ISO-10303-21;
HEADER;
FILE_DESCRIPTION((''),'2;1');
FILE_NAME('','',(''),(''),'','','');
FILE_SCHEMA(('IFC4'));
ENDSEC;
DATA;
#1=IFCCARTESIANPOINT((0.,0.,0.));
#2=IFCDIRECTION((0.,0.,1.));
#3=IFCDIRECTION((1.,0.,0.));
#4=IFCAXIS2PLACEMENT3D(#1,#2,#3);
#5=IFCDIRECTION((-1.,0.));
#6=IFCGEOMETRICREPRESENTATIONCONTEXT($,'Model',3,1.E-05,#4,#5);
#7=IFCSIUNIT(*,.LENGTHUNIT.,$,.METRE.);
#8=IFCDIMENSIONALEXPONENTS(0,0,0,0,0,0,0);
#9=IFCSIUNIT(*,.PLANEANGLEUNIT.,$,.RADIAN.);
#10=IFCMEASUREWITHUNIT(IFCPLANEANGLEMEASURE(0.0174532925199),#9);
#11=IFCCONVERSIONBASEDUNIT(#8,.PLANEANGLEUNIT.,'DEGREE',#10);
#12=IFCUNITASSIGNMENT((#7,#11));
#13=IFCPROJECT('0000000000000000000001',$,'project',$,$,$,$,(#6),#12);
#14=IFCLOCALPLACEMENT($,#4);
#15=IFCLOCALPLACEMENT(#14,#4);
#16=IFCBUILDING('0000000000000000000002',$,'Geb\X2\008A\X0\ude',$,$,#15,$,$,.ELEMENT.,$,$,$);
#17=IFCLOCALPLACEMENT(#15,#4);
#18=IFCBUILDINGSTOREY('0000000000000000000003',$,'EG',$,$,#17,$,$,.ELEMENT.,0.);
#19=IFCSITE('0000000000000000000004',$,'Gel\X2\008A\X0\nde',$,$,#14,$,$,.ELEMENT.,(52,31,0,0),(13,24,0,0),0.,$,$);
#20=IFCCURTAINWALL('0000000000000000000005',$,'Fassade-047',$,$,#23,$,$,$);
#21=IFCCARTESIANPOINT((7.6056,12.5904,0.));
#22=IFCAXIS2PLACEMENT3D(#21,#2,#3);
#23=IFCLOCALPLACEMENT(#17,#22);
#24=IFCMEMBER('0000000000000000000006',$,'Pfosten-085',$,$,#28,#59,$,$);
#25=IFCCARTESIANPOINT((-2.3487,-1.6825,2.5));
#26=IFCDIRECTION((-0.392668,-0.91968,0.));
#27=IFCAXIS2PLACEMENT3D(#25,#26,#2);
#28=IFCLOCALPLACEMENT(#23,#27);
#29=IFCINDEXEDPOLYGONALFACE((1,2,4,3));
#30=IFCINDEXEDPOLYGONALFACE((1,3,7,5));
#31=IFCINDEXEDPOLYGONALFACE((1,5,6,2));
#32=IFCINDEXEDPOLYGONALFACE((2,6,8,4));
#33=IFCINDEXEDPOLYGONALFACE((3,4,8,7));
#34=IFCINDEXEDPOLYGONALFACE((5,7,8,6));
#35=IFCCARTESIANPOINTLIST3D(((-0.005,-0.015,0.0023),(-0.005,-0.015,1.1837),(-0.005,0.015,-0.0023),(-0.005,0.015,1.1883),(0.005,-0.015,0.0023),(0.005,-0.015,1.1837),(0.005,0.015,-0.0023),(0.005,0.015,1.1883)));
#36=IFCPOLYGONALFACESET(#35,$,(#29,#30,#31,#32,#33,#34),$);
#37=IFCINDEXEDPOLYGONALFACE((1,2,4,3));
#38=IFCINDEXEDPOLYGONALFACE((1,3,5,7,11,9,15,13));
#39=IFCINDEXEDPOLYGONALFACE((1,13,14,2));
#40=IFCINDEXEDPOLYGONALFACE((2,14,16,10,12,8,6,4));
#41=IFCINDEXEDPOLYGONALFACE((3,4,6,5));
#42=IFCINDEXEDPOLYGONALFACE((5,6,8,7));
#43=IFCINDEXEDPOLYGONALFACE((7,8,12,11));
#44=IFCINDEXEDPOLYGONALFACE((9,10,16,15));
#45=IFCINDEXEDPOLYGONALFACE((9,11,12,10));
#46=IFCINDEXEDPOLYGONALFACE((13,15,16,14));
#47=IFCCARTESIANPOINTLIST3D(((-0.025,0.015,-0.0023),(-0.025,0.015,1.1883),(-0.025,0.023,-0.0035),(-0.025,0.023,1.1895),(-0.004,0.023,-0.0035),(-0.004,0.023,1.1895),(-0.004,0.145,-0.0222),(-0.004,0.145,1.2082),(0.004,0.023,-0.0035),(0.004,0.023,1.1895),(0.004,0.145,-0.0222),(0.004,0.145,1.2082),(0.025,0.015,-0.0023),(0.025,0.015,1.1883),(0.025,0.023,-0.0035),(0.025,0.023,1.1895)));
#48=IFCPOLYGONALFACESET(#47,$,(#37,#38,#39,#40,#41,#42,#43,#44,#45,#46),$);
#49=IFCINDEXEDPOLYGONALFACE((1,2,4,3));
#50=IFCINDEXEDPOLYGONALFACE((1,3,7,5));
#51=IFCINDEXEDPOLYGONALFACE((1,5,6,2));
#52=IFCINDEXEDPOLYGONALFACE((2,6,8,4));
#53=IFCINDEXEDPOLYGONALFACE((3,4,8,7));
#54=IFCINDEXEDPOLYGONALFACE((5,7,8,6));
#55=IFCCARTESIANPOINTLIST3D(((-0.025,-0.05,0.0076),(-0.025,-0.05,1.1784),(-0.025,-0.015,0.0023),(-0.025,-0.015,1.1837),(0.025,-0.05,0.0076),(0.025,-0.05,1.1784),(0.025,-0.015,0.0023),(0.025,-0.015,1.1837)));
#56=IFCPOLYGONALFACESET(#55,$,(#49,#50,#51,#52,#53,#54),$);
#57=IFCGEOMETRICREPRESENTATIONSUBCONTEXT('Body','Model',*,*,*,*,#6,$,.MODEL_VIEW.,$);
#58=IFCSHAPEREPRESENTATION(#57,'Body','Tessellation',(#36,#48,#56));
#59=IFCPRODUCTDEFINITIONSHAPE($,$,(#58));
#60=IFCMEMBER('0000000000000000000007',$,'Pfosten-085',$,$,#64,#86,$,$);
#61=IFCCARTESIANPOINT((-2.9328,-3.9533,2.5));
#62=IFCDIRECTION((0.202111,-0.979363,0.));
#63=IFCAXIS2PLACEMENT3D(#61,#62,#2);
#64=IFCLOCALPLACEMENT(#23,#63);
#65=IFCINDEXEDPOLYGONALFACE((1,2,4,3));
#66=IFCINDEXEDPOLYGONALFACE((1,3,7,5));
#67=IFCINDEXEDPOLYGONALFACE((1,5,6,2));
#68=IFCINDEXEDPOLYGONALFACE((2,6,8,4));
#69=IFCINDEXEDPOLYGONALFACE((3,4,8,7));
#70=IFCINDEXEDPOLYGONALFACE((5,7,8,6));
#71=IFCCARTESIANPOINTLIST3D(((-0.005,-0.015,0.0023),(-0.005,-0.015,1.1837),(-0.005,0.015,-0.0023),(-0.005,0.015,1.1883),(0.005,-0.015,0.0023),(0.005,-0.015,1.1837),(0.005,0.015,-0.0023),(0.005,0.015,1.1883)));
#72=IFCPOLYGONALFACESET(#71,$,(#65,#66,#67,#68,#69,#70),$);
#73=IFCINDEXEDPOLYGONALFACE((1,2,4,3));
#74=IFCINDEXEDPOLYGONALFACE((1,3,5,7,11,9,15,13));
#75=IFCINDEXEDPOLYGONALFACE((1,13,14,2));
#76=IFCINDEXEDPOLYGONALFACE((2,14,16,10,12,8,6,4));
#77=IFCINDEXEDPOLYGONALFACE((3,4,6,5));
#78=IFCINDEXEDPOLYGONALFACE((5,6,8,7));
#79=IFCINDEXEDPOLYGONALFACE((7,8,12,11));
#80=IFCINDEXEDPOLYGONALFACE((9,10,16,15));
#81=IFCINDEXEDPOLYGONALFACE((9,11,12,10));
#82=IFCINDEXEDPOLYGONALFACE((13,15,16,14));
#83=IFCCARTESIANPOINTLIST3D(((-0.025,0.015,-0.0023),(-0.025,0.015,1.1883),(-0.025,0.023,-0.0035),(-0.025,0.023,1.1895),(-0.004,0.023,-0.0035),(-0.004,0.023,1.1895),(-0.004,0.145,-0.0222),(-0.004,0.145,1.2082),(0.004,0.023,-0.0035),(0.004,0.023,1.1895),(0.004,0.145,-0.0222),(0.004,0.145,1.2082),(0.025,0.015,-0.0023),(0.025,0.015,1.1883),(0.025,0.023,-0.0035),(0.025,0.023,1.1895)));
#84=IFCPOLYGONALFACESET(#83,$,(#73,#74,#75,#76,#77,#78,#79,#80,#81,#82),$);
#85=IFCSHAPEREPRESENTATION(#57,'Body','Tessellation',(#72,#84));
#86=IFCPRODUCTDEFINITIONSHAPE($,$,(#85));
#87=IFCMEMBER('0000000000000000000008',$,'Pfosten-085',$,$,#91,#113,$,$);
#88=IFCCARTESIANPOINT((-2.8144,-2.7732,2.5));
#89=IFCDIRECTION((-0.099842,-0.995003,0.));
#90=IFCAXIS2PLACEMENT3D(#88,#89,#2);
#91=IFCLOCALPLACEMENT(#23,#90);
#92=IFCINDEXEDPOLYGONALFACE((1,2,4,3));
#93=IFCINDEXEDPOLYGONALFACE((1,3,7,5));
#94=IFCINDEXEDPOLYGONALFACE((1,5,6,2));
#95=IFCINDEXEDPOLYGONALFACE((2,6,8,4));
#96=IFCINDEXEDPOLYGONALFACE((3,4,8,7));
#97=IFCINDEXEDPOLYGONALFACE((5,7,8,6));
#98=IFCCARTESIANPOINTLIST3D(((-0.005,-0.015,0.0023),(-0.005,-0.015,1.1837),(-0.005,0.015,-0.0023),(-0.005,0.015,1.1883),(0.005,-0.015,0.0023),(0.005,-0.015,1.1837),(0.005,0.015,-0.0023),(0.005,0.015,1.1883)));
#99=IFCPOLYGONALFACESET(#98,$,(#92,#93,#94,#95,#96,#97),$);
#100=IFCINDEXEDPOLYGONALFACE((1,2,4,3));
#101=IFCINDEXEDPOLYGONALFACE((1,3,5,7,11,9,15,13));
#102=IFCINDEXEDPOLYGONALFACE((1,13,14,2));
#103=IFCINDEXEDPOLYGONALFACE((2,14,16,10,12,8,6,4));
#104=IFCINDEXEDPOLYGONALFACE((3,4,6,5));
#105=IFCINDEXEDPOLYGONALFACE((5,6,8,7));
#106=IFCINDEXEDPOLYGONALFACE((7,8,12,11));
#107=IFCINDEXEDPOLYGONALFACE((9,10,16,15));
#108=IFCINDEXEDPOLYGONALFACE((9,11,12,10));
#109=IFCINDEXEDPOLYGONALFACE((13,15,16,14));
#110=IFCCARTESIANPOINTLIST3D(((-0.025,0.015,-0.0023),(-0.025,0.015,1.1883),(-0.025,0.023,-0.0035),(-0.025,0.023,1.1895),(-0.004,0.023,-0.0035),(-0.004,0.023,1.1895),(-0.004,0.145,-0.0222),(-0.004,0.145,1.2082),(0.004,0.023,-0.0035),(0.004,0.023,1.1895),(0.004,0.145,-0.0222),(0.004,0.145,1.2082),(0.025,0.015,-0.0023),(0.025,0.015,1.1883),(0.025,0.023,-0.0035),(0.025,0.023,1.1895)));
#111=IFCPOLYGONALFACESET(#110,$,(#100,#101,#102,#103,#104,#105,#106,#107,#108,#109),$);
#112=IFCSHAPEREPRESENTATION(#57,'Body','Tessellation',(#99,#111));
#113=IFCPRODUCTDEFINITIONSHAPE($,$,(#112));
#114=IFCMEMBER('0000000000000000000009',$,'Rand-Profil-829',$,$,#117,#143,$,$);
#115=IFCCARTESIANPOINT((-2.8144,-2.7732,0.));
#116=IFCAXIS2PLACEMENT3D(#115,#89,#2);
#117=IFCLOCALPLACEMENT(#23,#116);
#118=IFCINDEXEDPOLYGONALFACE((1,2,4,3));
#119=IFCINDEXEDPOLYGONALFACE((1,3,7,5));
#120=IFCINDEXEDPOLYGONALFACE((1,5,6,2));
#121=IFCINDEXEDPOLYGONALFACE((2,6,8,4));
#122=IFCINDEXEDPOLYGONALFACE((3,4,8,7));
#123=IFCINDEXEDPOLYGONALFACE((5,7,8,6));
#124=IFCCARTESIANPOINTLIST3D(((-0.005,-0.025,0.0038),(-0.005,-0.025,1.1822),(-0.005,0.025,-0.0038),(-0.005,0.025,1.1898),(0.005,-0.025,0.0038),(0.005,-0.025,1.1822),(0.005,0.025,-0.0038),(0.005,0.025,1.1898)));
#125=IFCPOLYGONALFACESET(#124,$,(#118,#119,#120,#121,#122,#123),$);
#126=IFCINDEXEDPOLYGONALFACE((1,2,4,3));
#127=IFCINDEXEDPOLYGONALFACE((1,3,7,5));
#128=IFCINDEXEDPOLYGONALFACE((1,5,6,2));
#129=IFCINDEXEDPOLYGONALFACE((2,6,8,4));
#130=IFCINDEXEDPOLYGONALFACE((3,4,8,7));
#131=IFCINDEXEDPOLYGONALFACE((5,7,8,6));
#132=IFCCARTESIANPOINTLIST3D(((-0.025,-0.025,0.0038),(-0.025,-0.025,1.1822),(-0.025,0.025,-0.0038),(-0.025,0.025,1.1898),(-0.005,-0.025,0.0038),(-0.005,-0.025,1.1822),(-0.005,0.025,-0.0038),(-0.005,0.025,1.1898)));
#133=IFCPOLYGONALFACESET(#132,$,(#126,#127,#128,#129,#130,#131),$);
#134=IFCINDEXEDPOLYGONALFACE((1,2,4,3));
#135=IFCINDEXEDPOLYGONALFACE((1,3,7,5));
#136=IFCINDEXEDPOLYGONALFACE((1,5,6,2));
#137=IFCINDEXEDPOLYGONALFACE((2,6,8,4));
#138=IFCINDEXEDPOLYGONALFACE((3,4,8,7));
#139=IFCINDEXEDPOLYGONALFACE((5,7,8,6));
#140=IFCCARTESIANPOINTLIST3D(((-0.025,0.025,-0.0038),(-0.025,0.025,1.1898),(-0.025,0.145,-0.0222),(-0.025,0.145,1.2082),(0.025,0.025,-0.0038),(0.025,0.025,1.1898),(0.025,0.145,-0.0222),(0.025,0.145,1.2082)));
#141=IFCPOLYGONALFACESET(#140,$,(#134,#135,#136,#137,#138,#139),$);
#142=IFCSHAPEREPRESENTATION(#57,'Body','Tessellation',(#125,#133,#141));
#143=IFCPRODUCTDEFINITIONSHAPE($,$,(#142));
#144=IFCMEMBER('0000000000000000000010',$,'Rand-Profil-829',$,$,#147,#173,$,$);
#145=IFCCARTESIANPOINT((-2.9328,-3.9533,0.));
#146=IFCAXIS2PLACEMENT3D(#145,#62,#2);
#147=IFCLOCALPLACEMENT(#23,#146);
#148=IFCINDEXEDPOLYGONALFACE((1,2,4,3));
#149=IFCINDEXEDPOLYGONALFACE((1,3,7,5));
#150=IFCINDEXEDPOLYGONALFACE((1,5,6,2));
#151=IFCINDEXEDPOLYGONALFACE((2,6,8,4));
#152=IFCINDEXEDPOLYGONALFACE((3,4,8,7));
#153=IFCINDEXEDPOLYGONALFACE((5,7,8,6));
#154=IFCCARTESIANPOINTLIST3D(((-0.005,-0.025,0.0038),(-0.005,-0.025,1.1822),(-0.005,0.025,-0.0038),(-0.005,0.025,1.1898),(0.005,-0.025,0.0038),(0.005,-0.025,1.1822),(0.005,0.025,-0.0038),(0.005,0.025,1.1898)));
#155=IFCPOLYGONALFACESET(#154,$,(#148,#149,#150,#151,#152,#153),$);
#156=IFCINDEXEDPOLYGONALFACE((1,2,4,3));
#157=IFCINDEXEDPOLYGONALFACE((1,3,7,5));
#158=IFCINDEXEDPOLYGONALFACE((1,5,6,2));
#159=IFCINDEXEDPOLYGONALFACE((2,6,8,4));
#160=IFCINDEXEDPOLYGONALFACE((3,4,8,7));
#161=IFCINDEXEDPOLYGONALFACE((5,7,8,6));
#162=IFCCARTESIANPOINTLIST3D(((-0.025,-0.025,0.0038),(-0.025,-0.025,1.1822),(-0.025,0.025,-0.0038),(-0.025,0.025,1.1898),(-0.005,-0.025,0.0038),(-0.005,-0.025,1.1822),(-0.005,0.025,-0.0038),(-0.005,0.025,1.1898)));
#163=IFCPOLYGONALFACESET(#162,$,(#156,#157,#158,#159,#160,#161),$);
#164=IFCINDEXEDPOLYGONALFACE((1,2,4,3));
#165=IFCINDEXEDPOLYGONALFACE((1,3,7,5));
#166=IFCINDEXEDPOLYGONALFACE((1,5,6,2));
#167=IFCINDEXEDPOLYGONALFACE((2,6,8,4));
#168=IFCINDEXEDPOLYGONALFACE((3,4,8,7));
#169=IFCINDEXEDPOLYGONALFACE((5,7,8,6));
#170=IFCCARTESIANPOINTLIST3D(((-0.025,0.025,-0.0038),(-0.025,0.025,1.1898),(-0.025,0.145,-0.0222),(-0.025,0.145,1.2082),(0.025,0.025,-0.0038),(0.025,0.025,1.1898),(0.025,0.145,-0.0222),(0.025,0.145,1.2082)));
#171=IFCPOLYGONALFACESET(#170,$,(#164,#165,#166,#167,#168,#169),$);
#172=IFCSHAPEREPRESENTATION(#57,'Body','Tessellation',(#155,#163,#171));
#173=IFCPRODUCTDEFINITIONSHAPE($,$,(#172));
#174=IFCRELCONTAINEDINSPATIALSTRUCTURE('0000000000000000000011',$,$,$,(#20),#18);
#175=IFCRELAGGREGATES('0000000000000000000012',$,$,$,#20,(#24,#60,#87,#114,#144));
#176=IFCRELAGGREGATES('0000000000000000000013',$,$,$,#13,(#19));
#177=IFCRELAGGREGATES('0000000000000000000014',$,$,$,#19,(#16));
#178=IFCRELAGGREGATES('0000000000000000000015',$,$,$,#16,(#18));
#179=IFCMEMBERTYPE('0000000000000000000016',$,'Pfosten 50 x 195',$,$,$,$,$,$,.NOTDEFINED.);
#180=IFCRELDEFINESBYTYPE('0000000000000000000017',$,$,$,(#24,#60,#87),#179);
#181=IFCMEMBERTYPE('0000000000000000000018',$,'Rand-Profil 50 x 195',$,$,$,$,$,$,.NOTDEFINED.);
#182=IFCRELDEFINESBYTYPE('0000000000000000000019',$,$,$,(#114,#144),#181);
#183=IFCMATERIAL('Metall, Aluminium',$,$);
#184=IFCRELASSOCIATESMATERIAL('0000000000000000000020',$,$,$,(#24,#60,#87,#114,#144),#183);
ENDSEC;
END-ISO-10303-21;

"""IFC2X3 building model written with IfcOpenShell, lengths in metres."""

from ifc_helpers import new_model, entity, si_unit, converted_unit, direction, frame, origin_with_axes, place, context, subcontext, project, spatial, polyline, outline, extrude, clip, halfspace, material, type_object, element, aggregate, save


model = new_model("IFC2X3")

# Units and contexts
model_context = context("Model", 3, precision=1e-05, world=origin_with_axes(), true_north=direction((-1.0, 0.0)))
body_context = subcontext(model_context, "Body", "Model", "MODEL_VIEW")
ifc_project = project(units=[si_unit("LENGTHUNIT", "METRE"), converted_unit("PLANEANGLEUNIT", "DEGREE", entity("IfcPlaneAngleMeasure", 0.0174532925199), si_unit("PLANEANGLEUNIT", "RADIAN"), dimensions=[0, 0, 0, 0, 0, 0, 0])], contexts=[model_context])

# Site, building, storey
site_placement = place(None, origin_with_axes())
site = spatial("IfcSite", under=ifc_project, at=site_placement, Name="Gel\u008ande", CompositionType="ELEMENT", RefLatitude=(52, 31, 0, 0), RefLongitude=(13, 24, 0, 0), RefElevation=0.0)
building_placement = place(site_placement, origin_with_axes())
building = spatial("IfcBuilding", under=site, at=building_placement, Name="Geb\u008aude", CompositionType="ELEMENT")
storey_placement = place(building_placement, origin_with_axes())
storey = spatial("IfcBuildingStorey", under=building, at=storey_placement, Name="EG", CompositionType="ELEMENT", Elevation=0.0)

# Curtain wall, members
curtain_wall_placement = place(storey_placement, frame((7.6056, 12.5904, 0.0), z_axis=(0.0, 0.0, 1.0), x_axis=(1.0, 0.0, 0.0)))
curtain_wall = element("IfcCurtainWall", 1, at=curtain_wall_placement, inside=storey, Name="Fassade-047")
ifc_material_1 = material(Name="Metall, Aluminium")
member_type_1 = type_object("IfcMemberType", Name="Pfosten 50 x 195", PredefinedType="NOTDEFINED")
member_1_placement = place(curtain_wall_placement, frame((-2.3487, -1.6825, 2.5), z_axis=(-0.392668, -0.91968, 0.0), x_axis=(0.0, 0.0, 1.0)))
member_1 = element("IfcMember", 2, at=member_1_placement, type_object=member_type_1, material=ifc_material_1, Name="Pfosten-085", context=body_context, shape_type="Clipping", body=[
    clip(clip(extrude(outline(polyline([(0.015, -0.005), (0.015, 0.005), (-0.015, 0.005), (-0.015, -0.005), (0.015, -0.005)])), frame((0.0, 0.0, -0.0023), z_axis=(0.0, 0.0, 1.0), x_axis=(0.0, 1.0, 0.0)), (0.0, 0.0, 1.0), 1.1906), halfspace(frame((0.0, -0.1772, 1.1589), z_axis=(0.0, 0.151179, -0.988506), x_axis=(0.0, -0.988506, -0.151179)), True)), halfspace(frame((0.0, 0.0, 0.0), z_axis=(0.0, 0.151179, 0.988506), x_axis=(0.0, 0.988506, -0.151179)), True)),
    clip(clip(extrude(outline(polyline([(0.145, -0.004), (0.145, 0.004), (0.023, 0.004), (0.023, 0.025), (0.015, 0.025), (0.015, -0.025), (0.023, -0.025), (0.023, -0.004), (0.145, -0.004)])), frame((0.0, 0.0, -0.0222), z_axis=(0.0, 0.0, 1.0), x_axis=(0.0, 1.0, 0.0)), (0.0, 0.0, 1.0), 1.2304), halfspace(frame((0.0, -0.1772, 1.1589), z_axis=(0.0, 0.151179, -0.988506), x_axis=(0.0, -0.988506, -0.151179)), True)), halfspace(frame((0.0, 0.0, 0.0), z_axis=(0.0, 0.151179, 0.988506), x_axis=(0.0, 0.988506, -0.151179)), True)),
    clip(clip(extrude(outline(polyline([(-0.05, 0.025), (-0.05, -0.025), (-0.015, -0.025), (-0.015, 0.025), (-0.05, 0.025)])), frame((0.0, 0.0, 0.0023), z_axis=(0.0, 0.0, 1.0), x_axis=(0.0, 1.0, 0.0)), (0.0, 0.0, 1.0), 1.1814), halfspace(frame((0.0, -0.1772, 1.1589), z_axis=(0.0, 0.151179, -0.988506), x_axis=(0.0, -0.988506, -0.151179)), True)), halfspace(frame((0.0, 0.0, 0.0), z_axis=(0.0, 0.151179, 0.988506), x_axis=(0.0, 0.988506, -0.151179)), True)),
])
member_2_placement = place(curtain_wall_placement, frame((-2.9328, -3.9533, 2.5), z_axis=(0.202111, -0.979363, 0.0), x_axis=(0.0, 0.0, 1.0)))
member_2 = element("IfcMember", 3, at=member_2_placement, type_object=member_type_1, material=ifc_material_1, Name="Pfosten-085", context=body_context, shape_type="Clipping", body=[
    clip(clip(extrude(outline(polyline([(0.015, -0.005), (0.015, 0.005), (-0.015, 0.005), (-0.015, -0.005), (0.015, -0.005)])), frame((0.0, 0.0, -0.0023), z_axis=(0.0, 0.0, 1.0), x_axis=(0.0, 1.0, 0.0)), (0.0, 0.0, 1.0), 1.1906), halfspace(frame((0.0, -0.1772, 1.1589), z_axis=(0.0, 0.151179, -0.988506), x_axis=(0.0, -0.988506, -0.151179)), True)), halfspace(frame((0.0, 0.0, 0.0), z_axis=(0.0, 0.151179, 0.988506), x_axis=(0.0, 0.988506, -0.151179)), True)),
    clip(clip(extrude(outline(polyline([(0.145, -0.004), (0.145, 0.004), (0.023, 0.004), (0.023, 0.025), (0.015, 0.025), (0.015, -0.025), (0.023, -0.025), (0.023, -0.004), (0.145, -0.004)])), frame((0.0, 0.0, -0.0222), z_axis=(0.0, 0.0, 1.0), x_axis=(0.0, 1.0, 0.0)), (0.0, 0.0, 1.0), 1.2304), halfspace(frame((0.0, -0.1772, 1.1589), z_axis=(0.0, 0.151179, -0.988506), x_axis=(0.0, -0.988506, -0.151179)), True)), halfspace(frame((0.0, 0.0, 0.0), z_axis=(0.0, 0.151179, 0.988506), x_axis=(0.0, 0.988506, -0.151179)), True)),
])
member_3_placement = place(curtain_wall_placement, frame((-2.8144, -2.7732, 2.5), z_axis=(-0.099842, -0.995003, 0.0), x_axis=(0.0, 0.0, 1.0)))
member_3 = element("IfcMember", 4, at=member_3_placement, type_object=member_type_1, material=ifc_material_1, Name="Pfosten-085", context=body_context, shape_type="Clipping", body=[
    clip(clip(extrude(outline(polyline([(0.015, -0.005), (0.015, 0.005), (-0.015, 0.005), (-0.015, -0.005), (0.015, -0.005)])), frame((0.0, 0.0, -0.0023), z_axis=(0.0, 0.0, 1.0), x_axis=(0.0, 1.0, 0.0)), (0.0, 0.0, 1.0), 1.1906), halfspace(frame((0.0, -0.1772, 1.1589), z_axis=(0.0, 0.151179, -0.988506), x_axis=(0.0, -0.988506, -0.151179)), True)), halfspace(frame((0.0, 0.0, 0.0), z_axis=(0.0, 0.151179, 0.988506), x_axis=(0.0, 0.988506, -0.151179)), True)),
    clip(clip(extrude(outline(polyline([(0.145, -0.004), (0.145, 0.004), (0.023, 0.004), (0.023, 0.025), (0.015, 0.025), (0.015, -0.025), (0.023, -0.025), (0.023, -0.004), (0.145, -0.004)])), frame((0.0, 0.0, -0.0222), z_axis=(0.0, 0.0, 1.0), x_axis=(0.0, 1.0, 0.0)), (0.0, 0.0, 1.0), 1.2304), halfspace(frame((0.0, -0.1772, 1.1589), z_axis=(0.0, 0.151179, -0.988506), x_axis=(0.0, -0.988506, -0.151179)), True)), halfspace(frame((0.0, 0.0, 0.0), z_axis=(0.0, 0.151179, 0.988506), x_axis=(0.0, 0.988506, -0.151179)), True)),
])
member_type_2 = type_object("IfcMemberType", Name="Rand-Profil 50 x 195", PredefinedType="NOTDEFINED")
member_4_placement = place(curtain_wall_placement, frame((-2.8144, -2.7732, 0.0), z_axis=(-0.099842, -0.995003, 0.0), x_axis=(0.0, 0.0, 1.0)))
member_4 = element("IfcMember", 5, at=member_4_placement, type_object=member_type_2, material=ifc_material_1, Name="Rand-Profil-829", context=body_context, shape_type="Clipping", body=[
    clip(clip(extrude(outline(polyline([(0.025, -0.005), (0.025, 0.005), (-0.025, 0.005), (-0.025, -0.005), (0.025, -0.005)])), frame((0.0, 0.0, -0.0038), z_axis=(0.0, 0.0, 1.0), x_axis=(0.0, 1.0, 0.0)), (0.0, 0.0, 1.0), 1.1936), halfspace(frame((0.0, -0.1772, 1.1589), z_axis=(0.0, 0.151179, -0.988506), x_axis=(0.0, -0.988506, -0.151179)), True)), halfspace(frame((0.0, 0.0, 0.0), z_axis=(0.0, 0.151179, 0.988506), x_axis=(0.0, 0.988506, -0.151179)), True)),
    clip(clip(extrude(outline(polyline([(0.025, 0.005), (0.025, 0.025), (-0.025, 0.025), (-0.025, 0.005), (0.025, 0.005)])), frame((0.0, 0.0, -0.0038), z_axis=(0.0, 0.0, 1.0), x_axis=(0.0, 1.0, 0.0)), (0.0, 0.0, 1.0), 1.1936), halfspace(frame((0.0, -0.1772, 1.1589), z_axis=(0.0, 0.151179, -0.988506), x_axis=(0.0, -0.988506, -0.151179)), True)), halfspace(frame((0.0, 0.0, 0.0), z_axis=(0.0, 0.151179, 0.988506), x_axis=(0.0, 0.988506, -0.151179)), True)),
    clip(clip(extrude(outline(polyline([(0.145, -0.025), (0.145, 0.025), (0.025, 0.025), (0.025, -0.025), (0.145, -0.025)])), frame((0.0, 0.0, -0.0222), z_axis=(0.0, 0.0, 1.0), x_axis=(0.0, 1.0, 0.0)), (0.0, 0.0, 1.0), 1.2304), halfspace(frame((0.0, -0.1772, 1.1589), z_axis=(0.0, 0.151179, -0.988506), x_axis=(0.0, -0.988506, -0.151179)), True)), halfspace(frame((0.0, 0.0, 0.0), z_axis=(0.0, 0.151179, 0.988506), x_axis=(0.0, 0.988506, -0.151179)), True)),
])
member_5_placement = place(curtain_wall_placement, frame((-2.9328, -3.9533, 0.0), z_axis=(0.202111, -0.979363, 0.0), x_axis=(0.0, 0.0, 1.0)))
member_5 = element("IfcMember", 6, at=member_5_placement, type_object=member_type_2, material=ifc_material_1, Name="Rand-Profil-829", context=body_context, shape_type="Clipping", body=[
    clip(clip(extrude(outline(polyline([(0.025, -0.005), (0.025, 0.005), (-0.025, 0.005), (-0.025, -0.005), (0.025, -0.005)])), frame((0.0, 0.0, -0.0038), z_axis=(0.0, 0.0, 1.0), x_axis=(0.0, 1.0, 0.0)), (0.0, 0.0, 1.0), 1.1936), halfspace(frame((0.0, -0.1772, 1.1589), z_axis=(0.0, 0.151179, -0.988506), x_axis=(0.0, -0.988506, -0.151179)), True)), halfspace(frame((0.0, 0.0, 0.0), z_axis=(0.0, 0.151179, 0.988506), x_axis=(0.0, 0.988506, -0.151179)), True)),
    clip(clip(extrude(outline(polyline([(0.025, 0.005), (0.025, 0.025), (-0.025, 0.025), (-0.025, 0.005), (0.025, 0.005)])), frame((0.0, 0.0, -0.0038), z_axis=(0.0, 0.0, 1.0), x_axis=(0.0, 1.0, 0.0)), (0.0, 0.0, 1.0), 1.1936), halfspace(frame((0.0, -0.1772, 1.1589), z_axis=(0.0, 0.151179, -0.988506), x_axis=(0.0, -0.988506, -0.151179)), True)), halfspace(frame((0.0, 0.0, 0.0), z_axis=(0.0, 0.151179, 0.988506), x_axis=(0.0, 0.988506, -0.151179)), True)),
    clip(clip(extrude(outline(polyline([(0.145, -0.025), (0.145, 0.025), (0.025, 0.025), (0.025, -0.025), (0.145, -0.025)])), frame((0.0, 0.0, -0.0222), z_axis=(0.0, 0.0, 1.0), x_axis=(0.0, 1.0, 0.0)), (0.0, 0.0, 1.0), 1.2304), halfspace(frame((0.0, -0.1772, 1.1589), z_axis=(0.0, 0.151179, -0.988506), x_axis=(0.0, -0.988506, -0.151179)), True)), halfspace(frame((0.0, 0.0, 0.0), z_axis=(0.0, 0.151179, 0.988506), x_axis=(0.0, 0.988506, -0.151179)), True)),
])

aggregate(curtain_wall, [member_1, member_2, member_3, member_4, member_5])

save(model, "model.ifc")
